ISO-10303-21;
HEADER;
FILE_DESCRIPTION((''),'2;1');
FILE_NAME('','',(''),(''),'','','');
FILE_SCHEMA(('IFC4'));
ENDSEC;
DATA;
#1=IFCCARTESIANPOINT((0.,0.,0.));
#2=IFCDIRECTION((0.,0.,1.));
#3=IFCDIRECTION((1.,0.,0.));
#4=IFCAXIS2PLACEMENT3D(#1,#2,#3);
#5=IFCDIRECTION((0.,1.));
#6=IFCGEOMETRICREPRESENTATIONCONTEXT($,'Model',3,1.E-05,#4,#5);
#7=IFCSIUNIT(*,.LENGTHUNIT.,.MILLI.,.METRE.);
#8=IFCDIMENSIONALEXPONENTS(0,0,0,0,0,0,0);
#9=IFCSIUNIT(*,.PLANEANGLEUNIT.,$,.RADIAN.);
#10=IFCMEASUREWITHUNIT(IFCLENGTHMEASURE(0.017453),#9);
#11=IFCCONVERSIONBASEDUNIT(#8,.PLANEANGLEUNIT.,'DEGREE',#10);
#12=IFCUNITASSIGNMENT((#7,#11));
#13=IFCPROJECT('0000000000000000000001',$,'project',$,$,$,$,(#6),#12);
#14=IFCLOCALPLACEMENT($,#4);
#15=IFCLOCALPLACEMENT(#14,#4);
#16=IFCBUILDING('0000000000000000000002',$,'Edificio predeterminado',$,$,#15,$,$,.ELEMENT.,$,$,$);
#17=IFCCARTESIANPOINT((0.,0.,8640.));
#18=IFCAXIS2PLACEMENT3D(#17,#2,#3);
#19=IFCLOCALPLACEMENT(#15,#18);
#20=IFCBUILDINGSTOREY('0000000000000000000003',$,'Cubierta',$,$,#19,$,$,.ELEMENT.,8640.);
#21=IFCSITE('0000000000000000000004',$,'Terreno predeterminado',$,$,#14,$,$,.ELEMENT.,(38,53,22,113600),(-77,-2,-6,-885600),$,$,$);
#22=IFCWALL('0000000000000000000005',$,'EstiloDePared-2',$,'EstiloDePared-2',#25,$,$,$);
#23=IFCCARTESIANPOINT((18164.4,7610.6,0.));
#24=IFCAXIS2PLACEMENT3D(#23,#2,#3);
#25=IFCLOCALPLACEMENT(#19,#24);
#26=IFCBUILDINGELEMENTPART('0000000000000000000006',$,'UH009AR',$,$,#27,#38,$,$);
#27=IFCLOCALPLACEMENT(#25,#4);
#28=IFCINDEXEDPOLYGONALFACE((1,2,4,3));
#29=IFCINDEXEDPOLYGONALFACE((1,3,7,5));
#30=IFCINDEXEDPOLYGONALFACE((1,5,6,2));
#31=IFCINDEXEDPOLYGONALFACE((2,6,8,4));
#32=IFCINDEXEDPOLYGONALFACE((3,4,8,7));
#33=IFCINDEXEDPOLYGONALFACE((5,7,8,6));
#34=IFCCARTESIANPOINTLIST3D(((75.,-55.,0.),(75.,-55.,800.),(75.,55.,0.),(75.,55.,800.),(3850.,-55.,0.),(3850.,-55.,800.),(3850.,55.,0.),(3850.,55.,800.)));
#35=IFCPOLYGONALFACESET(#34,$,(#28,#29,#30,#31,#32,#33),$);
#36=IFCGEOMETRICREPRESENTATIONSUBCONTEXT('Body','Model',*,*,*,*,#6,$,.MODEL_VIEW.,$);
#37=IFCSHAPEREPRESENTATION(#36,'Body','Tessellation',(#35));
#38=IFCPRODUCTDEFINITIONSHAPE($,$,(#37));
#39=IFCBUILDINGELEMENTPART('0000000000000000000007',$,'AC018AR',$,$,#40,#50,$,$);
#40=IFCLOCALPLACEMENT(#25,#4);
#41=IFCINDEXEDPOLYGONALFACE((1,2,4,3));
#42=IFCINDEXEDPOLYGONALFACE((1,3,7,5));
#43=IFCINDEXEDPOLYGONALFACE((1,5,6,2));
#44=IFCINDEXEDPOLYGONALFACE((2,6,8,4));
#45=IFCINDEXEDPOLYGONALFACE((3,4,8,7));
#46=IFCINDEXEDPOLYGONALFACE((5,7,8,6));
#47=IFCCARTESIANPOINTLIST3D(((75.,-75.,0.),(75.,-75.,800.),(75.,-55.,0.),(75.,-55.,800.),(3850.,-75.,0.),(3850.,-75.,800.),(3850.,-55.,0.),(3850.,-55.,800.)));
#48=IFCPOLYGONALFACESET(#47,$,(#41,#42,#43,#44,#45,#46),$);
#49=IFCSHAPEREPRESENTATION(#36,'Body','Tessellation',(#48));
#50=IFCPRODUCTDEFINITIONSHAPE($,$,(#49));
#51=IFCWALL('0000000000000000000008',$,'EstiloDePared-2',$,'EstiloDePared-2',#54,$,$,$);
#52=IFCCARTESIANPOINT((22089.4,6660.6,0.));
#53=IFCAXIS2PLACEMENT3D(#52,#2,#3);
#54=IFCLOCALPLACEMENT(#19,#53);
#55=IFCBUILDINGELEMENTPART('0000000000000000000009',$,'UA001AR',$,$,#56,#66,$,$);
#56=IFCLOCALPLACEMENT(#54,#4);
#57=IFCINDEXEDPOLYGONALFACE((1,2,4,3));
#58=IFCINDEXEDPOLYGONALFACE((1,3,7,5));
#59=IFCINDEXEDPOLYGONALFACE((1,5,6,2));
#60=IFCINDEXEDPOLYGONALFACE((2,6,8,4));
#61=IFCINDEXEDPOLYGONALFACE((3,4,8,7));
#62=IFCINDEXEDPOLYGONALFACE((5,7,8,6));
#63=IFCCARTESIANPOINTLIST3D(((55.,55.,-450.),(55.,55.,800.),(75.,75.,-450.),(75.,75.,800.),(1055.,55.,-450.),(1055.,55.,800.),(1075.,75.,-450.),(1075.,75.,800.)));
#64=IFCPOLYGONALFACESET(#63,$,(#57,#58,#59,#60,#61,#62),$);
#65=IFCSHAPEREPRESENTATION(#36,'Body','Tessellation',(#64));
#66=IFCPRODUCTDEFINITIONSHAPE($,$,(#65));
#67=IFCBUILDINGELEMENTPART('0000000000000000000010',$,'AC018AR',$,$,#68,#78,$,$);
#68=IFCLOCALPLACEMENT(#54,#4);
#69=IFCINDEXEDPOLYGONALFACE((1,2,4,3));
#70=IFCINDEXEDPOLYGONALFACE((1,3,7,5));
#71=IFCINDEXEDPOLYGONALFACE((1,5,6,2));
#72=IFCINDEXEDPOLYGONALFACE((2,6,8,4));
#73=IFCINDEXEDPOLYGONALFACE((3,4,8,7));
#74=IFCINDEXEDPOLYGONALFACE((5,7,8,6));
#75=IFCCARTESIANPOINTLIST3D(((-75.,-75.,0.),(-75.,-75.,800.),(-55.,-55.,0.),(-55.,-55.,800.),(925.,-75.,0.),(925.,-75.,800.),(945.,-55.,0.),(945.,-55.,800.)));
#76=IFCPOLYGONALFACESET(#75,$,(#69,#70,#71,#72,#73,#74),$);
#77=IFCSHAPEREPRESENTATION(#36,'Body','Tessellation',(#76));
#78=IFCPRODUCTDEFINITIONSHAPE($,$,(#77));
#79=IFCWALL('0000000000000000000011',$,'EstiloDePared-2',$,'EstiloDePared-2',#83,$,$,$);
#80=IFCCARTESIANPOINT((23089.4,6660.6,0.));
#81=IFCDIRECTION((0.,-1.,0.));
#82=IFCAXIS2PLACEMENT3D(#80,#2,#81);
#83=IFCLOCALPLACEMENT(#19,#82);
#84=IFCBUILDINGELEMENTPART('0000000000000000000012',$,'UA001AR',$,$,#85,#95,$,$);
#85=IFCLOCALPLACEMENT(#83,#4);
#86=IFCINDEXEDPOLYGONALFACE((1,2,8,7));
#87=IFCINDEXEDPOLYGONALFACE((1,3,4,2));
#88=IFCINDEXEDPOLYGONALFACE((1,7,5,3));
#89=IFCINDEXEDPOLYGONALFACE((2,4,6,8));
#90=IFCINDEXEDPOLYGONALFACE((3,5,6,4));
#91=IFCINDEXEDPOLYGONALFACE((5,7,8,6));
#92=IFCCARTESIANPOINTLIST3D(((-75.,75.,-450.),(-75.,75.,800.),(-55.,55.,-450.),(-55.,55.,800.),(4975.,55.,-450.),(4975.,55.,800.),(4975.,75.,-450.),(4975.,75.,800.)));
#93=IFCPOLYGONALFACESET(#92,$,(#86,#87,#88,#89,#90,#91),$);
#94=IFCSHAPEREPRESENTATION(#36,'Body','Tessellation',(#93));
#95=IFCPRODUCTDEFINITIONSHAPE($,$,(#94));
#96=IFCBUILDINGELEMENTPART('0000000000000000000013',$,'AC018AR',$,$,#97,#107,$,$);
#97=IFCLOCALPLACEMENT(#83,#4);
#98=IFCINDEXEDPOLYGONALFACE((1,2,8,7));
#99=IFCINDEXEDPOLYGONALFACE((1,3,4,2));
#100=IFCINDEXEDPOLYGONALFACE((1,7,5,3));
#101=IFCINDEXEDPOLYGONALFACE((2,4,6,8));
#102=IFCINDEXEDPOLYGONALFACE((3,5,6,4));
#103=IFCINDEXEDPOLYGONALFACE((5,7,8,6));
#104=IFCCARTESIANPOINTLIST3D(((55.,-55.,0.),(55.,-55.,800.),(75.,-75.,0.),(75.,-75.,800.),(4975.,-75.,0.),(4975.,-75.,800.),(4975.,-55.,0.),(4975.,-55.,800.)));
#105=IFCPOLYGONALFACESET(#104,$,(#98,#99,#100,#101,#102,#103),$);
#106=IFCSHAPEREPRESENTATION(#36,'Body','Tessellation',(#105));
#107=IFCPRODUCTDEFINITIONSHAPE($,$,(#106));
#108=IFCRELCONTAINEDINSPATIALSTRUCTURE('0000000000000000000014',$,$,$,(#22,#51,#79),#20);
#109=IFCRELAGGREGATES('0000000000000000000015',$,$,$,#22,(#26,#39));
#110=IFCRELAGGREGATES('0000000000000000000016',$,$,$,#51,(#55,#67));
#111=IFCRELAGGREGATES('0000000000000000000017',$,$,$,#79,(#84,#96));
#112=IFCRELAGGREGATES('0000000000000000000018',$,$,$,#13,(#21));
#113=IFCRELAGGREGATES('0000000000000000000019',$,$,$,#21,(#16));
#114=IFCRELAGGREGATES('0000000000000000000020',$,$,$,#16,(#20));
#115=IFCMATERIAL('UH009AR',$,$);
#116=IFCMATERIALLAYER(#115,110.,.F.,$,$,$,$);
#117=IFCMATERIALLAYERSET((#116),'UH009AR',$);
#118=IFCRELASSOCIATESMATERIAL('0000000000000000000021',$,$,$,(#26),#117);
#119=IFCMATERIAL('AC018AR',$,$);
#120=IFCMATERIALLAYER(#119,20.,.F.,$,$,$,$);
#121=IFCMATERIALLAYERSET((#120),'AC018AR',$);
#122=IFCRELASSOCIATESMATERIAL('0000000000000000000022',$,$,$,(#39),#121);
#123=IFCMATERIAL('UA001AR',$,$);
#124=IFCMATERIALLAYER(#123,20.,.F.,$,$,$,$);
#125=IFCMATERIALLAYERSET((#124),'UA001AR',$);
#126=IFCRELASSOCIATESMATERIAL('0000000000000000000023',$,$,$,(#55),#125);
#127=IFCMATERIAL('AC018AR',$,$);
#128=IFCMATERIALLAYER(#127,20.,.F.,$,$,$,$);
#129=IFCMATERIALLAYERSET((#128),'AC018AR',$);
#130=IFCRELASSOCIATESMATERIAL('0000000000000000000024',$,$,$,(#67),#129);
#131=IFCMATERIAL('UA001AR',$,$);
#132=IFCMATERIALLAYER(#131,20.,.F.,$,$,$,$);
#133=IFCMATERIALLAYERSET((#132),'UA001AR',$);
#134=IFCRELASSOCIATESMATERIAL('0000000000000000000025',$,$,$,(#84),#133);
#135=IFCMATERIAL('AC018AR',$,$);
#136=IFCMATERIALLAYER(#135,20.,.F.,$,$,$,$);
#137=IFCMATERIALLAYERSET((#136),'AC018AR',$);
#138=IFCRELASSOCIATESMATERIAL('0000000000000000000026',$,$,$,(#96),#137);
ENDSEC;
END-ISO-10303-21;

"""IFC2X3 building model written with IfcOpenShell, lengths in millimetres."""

from ifc_helpers import new_model, entity, si_unit, converted_unit, direction, frame, origin_with_axes, place, context, subcontext, project, spatial, polyline, outline, extrude, material, layer, layer_set, layer_usage, element, aggregate, save


model = new_model("IFC2X3")

# Units and contexts
model_context = context("Model", 3, precision=1e-05, world=origin_with_axes(), true_north=direction((0.0, 1.0)))
body_context = subcontext(model_context, "Body", "Model", "MODEL_VIEW")
ifc_project = project(units=[si_unit("LENGTHUNIT", "METRE", prefix="MILLI"), converted_unit("PLANEANGLEUNIT", "DEGREE", entity("IfcLengthMeasure", 0.017453), si_unit("PLANEANGLEUNIT", "RADIAN"), dimensions=[0, 0, 0, 0, 0, 0, 0])], contexts=[model_context])

# Site, building, storey
site_placement = place(None, origin_with_axes())
site = spatial("IfcSite", under=ifc_project, at=site_placement, Name="Terreno predeterminado", CompositionType="ELEMENT", RefLatitude=(38, 53, 22, 113600), RefLongitude=(-77, -2, -6, -885600))
building_placement = place(site_placement, origin_with_axes())
building = spatial("IfcBuilding", under=site, at=building_placement, Name="Edificio predeterminado", CompositionType="ELEMENT")
storey_placement = place(building_placement, frame((0.0, 0.0, 8640.0), z_axis=(0.0, 0.0, 1.0), x_axis=(1.0, 0.0, 0.0)))
storey = spatial("IfcBuildingStorey", under=building, at=storey_placement, Name="Cubierta", CompositionType="ELEMENT", Elevation=8640.0)

# Walls, building element parts
wall_1_placement = place(storey_placement, frame((18164.4, 7610.6, 0.0), z_axis=(0.0, 0.0, 1.0), x_axis=(1.0, 0.0, 0.0)))
wall_1 = element("IfcWall", 1, at=wall_1_placement, inside=storey, Name="EstiloDePared-2", ObjectType="EstiloDePared-2")
ifc_material_1 = material(Name="UH009AR")
ifc_layer_1 = layer(ifc_material_1, 110.0, ventilated=False)
ifc_layer_set_1 = layer_set([ifc_layer_1], Name="UH009AR")
ifc_layer_usage_1 = layer_usage(ifc_layer_set_1, "AXIS2", "NEGATIVE", -55.0)
building_element_part_1_placement = place(wall_1_placement, origin_with_axes())
building_element_part_1 = element("IfcBuildingElementPart", 2, at=building_element_part_1_placement, material=ifc_layer_usage_1, Name="UH009AR", context=body_context, shape_type="SweptSolid", body=[
    extrude(outline(polyline([(3850.0, 55.0), (3850.0, -55.0), (75.0, -55.0), (75.0, 55.0), (3850.0, 55.0)])), origin_with_axes(), (0.0, 0.0, 1.0), 800.0),
])
ifc_material_2 = material(Name="AC018AR")
ifc_layer_2 = layer(ifc_material_2, 20.0, ventilated=False)
ifc_layer_set_2 = layer_set([ifc_layer_2], Name="AC018AR")
ifc_layer_usage_2 = layer_usage(ifc_layer_set_2, "AXIS2", "NEGATIVE", 55.0)
building_element_part_2_placement = place(wall_1_placement, origin_with_axes())
building_element_part_2 = element("IfcBuildingElementPart", 3, at=building_element_part_2_placement, material=ifc_layer_usage_2, Name="AC018AR", context=body_context, shape_type="SweptSolid", body=[
    extrude(outline(polyline([(3850.0, -55.0), (3850.0, -75.0), (75.0, -75.0), (75.0, -55.0), (3850.0, -55.0)])), origin_with_axes(), (0.0, 0.0, 1.0), 800.0),
])
aggregate(wall_1, [building_element_part_1, building_element_part_2])
wall_2_placement = place(storey_placement, frame((22089.4, 6660.6, 0.0), z_axis=(0.0, 0.0, 1.0), x_axis=(1.0, 0.0, 0.0)))
wall_2 = element("IfcWall", 4, at=wall_2_placement, inside=storey, Name="EstiloDePared-2", ObjectType="EstiloDePared-2")
ifc_material_3 = material(Name="UA001AR")
ifc_layer_3 = layer(ifc_material_3, 20.0, ventilated=False)
ifc_layer_set_3 = layer_set([ifc_layer_3], Name="UA001AR")
ifc_layer_usage_3 = layer_usage(ifc_layer_set_3, "AXIS2", "NEGATIVE", -75.0)
building_element_part_3_placement = place(wall_2_placement, origin_with_axes())
building_element_part_3 = element("IfcBuildingElementPart", 5, at=building_element_part_3_placement, material=ifc_layer_usage_3, Name="UA001AR", context=body_context, shape_type="SweptSolid", body=[
    extrude(outline(polyline([(1075.0, 75.0), (1055.0, 55.0), (55.0, 55.0), (75.0, 75.0), (1075.0, 75.0)])), frame((0.0, 0.0, -450.0), z_axis=(0.0, 0.0, 1.0), x_axis=(1.0, 0.0, 0.0)), (0.0, 0.0, 1.0), 1250.0),
])
ifc_material_4 = material(Name="AC018AR")
ifc_layer_4 = layer(ifc_material_4, 20.0, ventilated=False)
ifc_layer_set_4 = layer_set([ifc_layer_4], Name="AC018AR")
ifc_layer_usage_4 = layer_usage(ifc_layer_set_4, "AXIS2", "NEGATIVE", 55.0)
building_element_part_4_placement = place(wall_2_placement, origin_with_axes())
building_element_part_4 = element("IfcBuildingElementPart", 6, at=building_element_part_4_placement, material=ifc_layer_usage_4, Name="AC018AR", context=body_context, shape_type="SweptSolid", body=[
    extrude(outline(polyline([(945.0, -55.0), (925.0, -75.0), (-75.0, -75.0), (-55.0, -55.0), (945.0, -55.0)])), origin_with_axes(), (0.0, 0.0, 1.0), 800.0),
])
aggregate(wall_2, [building_element_part_3, building_element_part_4])
wall_3_placement = place(storey_placement, frame((23089.4, 6660.6, 0.0), z_axis=(0.0, 0.0, 1.0), x_axis=(0.0, -1.0, 0.0)))
wall_3 = element("IfcWall", 7, at=wall_3_placement, inside=storey, Name="EstiloDePared-2", ObjectType="EstiloDePared-2")
ifc_material_5 = material(Name="UA001AR")
ifc_layer_5 = layer(ifc_material_5, 20.0, ventilated=False)
ifc_layer_set_5 = layer_set([ifc_layer_5], Name="UA001AR")
ifc_layer_usage_5 = layer_usage(ifc_layer_set_5, "AXIS2", "NEGATIVE", -75.0)
building_element_part_5_placement = place(wall_3_placement, origin_with_axes())
building_element_part_5 = element("IfcBuildingElementPart", 8, at=building_element_part_5_placement, material=ifc_layer_usage_5, Name="UA001AR", context=body_context, shape_type="SweptSolid", body=[
    extrude(outline(polyline([(4975.0, 75.0), (4975.0, 55.0), (-55.0, 55.0), (-75.0, 75.0), (4975.0, 75.0)])), frame((0.0, 0.0, -450.0), z_axis=(0.0, 0.0, 1.0), x_axis=(1.0, 0.0, 0.0)), (0.0, 0.0, 1.0), 1250.0),
])
ifc_material_6 = material(Name="AC018AR")
ifc_layer_6 = layer(ifc_material_6, 20.0, ventilated=False)
ifc_layer_set_6 = layer_set([ifc_layer_6], Name="AC018AR")
ifc_layer_usage_6 = layer_usage(ifc_layer_set_6, "AXIS2", "NEGATIVE", 55.0)
building_element_part_6_placement = place(wall_3_placement, origin_with_axes())
building_element_part_6 = element("IfcBuildingElementPart", 9, at=building_element_part_6_placement, material=ifc_layer_usage_6, Name="AC018AR", context=body_context, shape_type="SweptSolid", body=[
    extrude(outline(polyline([(4975.0, -55.0), (4975.0, -75.0), (75.0, -75.0), (55.0, -55.0), (4975.0, -55.0)])), origin_with_axes(), (0.0, 0.0, 1.0), 800.0),
])
aggregate(wall_3, [building_element_part_5, building_element_part_6])

save(model, "model.ifc")
